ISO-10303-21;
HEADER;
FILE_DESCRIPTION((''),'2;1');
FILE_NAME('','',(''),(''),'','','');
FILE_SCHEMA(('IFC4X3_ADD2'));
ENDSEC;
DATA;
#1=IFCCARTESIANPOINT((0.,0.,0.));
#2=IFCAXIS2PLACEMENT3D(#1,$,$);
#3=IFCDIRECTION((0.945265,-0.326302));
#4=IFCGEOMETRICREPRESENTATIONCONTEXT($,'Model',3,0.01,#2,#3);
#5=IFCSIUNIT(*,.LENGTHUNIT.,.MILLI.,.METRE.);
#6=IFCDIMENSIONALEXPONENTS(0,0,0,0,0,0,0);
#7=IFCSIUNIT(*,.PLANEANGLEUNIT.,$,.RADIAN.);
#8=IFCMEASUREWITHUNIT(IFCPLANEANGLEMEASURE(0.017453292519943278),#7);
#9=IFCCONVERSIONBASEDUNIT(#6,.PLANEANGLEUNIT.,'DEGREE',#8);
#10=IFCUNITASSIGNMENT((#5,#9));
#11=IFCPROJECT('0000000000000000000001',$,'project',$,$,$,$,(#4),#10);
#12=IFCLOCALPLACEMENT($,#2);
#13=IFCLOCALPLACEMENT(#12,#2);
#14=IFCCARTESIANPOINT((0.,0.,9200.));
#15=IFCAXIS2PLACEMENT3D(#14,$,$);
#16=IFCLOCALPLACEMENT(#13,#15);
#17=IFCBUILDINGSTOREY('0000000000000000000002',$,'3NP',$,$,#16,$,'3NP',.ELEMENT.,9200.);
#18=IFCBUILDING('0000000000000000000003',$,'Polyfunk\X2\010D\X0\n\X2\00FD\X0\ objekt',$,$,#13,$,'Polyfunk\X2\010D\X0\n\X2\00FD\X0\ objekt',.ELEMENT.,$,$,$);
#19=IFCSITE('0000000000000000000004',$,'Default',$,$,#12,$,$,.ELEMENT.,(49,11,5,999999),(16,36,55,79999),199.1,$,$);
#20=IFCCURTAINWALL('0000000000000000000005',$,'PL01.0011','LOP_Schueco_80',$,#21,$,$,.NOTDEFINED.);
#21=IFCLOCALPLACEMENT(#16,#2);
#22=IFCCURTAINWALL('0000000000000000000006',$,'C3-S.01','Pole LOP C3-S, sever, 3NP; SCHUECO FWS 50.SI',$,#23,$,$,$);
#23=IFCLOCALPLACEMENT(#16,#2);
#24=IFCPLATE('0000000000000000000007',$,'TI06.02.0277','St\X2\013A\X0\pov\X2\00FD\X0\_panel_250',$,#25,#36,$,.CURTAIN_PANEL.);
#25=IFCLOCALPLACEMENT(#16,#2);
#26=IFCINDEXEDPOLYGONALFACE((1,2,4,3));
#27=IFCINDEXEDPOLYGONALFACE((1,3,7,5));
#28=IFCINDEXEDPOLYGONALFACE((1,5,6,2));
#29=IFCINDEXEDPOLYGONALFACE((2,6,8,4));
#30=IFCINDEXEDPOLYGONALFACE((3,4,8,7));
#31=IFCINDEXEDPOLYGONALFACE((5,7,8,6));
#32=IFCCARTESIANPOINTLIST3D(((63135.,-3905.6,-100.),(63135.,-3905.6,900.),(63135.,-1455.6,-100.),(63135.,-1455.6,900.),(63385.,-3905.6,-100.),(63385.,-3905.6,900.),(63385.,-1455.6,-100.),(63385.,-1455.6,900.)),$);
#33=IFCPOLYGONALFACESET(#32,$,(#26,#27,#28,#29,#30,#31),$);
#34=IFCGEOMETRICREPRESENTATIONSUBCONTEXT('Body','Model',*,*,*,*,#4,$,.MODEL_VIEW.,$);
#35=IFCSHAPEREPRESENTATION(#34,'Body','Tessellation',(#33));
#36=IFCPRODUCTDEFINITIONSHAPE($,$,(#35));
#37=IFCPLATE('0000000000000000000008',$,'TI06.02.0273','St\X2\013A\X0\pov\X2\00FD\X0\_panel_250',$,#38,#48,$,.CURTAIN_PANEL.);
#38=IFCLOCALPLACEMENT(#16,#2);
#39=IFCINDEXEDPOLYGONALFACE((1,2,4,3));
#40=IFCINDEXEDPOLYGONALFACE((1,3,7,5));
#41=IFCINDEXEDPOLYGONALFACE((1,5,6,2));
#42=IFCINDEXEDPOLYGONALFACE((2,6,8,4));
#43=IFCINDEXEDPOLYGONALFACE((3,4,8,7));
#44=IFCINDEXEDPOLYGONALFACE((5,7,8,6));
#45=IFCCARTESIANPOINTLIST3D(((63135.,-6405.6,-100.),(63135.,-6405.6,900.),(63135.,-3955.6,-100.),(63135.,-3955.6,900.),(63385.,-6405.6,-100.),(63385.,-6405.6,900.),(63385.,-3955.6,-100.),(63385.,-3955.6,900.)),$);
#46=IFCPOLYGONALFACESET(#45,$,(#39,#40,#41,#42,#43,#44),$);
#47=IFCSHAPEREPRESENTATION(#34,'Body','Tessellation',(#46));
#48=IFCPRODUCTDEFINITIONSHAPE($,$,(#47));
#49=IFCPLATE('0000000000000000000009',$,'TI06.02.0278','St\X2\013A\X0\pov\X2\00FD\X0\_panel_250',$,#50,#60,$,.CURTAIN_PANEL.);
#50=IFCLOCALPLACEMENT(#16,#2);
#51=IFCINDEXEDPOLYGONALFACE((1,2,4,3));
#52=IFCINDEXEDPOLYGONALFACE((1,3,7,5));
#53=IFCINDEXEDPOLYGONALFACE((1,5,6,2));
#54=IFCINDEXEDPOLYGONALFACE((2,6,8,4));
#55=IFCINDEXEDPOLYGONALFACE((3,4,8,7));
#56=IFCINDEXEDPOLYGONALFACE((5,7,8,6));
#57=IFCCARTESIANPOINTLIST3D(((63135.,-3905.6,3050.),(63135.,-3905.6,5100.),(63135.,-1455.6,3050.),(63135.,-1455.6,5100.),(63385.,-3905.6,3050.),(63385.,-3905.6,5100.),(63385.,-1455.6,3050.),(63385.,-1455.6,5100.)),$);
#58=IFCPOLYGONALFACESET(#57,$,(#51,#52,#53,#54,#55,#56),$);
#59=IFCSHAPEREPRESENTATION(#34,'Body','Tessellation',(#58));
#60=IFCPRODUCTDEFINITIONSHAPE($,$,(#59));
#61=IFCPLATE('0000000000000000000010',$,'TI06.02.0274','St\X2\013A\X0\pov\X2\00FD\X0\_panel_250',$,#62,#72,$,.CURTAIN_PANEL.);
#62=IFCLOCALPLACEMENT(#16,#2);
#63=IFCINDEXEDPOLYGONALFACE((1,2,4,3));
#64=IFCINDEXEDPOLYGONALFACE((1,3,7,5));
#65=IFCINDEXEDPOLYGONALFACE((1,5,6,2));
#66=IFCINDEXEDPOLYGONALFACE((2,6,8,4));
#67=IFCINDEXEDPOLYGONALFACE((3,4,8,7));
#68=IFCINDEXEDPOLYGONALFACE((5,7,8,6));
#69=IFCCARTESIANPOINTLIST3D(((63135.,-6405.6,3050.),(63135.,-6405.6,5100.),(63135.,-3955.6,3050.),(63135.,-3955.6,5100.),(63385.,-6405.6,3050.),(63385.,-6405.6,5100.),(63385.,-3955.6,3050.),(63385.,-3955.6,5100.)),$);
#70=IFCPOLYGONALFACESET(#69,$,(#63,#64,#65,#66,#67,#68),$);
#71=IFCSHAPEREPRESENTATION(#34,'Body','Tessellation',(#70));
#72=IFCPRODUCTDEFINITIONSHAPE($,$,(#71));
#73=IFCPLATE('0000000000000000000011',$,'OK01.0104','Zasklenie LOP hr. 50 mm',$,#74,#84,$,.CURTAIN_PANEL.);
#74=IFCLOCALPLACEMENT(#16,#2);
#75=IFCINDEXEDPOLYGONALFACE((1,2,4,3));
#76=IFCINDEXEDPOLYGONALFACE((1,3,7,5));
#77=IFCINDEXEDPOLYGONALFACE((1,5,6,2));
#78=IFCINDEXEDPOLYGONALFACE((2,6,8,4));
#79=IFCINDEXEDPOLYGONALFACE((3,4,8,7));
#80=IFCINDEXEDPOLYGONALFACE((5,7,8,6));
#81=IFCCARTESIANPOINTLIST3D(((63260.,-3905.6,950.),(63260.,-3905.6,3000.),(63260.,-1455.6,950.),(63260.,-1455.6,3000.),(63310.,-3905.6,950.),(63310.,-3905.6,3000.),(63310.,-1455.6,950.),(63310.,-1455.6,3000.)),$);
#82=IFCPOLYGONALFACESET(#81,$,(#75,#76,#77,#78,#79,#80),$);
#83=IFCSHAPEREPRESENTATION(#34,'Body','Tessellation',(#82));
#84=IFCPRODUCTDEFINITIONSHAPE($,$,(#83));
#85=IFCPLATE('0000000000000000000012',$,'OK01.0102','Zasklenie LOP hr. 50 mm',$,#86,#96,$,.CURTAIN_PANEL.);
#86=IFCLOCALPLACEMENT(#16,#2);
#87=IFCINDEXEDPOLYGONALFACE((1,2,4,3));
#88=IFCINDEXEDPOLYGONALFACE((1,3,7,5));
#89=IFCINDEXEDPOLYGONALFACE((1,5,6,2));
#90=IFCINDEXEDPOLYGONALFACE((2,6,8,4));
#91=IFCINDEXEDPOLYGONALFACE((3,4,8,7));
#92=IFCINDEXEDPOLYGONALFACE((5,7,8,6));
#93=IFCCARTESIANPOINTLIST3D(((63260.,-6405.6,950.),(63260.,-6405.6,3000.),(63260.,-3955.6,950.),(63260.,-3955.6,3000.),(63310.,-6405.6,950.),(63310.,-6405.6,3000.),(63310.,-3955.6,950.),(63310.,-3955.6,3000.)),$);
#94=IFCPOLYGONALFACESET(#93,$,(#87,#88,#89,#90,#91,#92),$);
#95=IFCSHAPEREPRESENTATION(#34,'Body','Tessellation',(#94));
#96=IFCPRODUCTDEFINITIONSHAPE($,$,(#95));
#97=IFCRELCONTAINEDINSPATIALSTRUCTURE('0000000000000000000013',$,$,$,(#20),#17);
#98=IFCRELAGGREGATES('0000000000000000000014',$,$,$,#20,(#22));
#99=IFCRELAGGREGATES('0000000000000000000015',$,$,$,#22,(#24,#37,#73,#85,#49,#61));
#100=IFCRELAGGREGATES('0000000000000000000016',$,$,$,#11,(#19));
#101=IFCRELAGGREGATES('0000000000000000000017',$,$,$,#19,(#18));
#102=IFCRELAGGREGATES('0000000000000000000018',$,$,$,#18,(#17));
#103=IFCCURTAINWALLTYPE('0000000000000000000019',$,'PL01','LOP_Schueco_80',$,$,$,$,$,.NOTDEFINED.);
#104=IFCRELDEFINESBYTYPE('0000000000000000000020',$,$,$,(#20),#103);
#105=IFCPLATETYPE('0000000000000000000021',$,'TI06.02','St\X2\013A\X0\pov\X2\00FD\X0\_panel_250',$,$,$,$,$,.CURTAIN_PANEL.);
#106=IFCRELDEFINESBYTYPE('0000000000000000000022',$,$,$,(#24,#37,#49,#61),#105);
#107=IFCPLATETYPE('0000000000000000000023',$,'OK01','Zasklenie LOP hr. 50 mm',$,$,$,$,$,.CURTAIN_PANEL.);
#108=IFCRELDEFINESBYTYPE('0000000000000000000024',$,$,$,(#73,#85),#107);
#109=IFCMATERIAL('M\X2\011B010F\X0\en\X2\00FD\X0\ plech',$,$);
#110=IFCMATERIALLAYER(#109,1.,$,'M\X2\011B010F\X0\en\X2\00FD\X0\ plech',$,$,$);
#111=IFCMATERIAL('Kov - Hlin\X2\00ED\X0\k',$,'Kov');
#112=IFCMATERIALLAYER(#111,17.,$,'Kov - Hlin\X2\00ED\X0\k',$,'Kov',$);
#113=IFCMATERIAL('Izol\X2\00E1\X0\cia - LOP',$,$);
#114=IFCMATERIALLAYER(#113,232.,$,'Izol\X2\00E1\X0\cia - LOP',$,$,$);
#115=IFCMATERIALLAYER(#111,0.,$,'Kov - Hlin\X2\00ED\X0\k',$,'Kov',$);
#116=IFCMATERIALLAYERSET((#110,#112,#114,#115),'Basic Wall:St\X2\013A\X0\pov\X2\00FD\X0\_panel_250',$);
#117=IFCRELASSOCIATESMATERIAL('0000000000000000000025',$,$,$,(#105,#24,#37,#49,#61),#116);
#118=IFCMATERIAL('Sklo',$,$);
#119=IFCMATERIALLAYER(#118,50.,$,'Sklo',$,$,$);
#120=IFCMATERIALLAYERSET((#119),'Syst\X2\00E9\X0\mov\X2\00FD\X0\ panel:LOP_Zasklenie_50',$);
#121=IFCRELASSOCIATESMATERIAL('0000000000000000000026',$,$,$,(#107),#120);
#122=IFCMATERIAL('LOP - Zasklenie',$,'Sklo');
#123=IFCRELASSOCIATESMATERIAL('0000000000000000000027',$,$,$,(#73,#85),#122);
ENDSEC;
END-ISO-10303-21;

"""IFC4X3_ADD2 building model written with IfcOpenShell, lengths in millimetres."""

from ifc_helpers import new_model, entity, si_unit, converted_unit, direction, frame, frame_2d, origin, origin_2d_with_axis, place, context, subcontext, project, spatial, rectangle, extrude, source, transform, mapped, material, layer, layer_set, layer_usage, type_object, type_shapes, element, aggregate, save


model = new_model("IFC4X3_ADD2")

# Units and contexts
model_context = context("Model", 3, precision=0.01, world=origin(), true_north=direction((0.945265, -0.326302)))
body_context = subcontext(model_context, "Body", "Model", "MODEL_VIEW")
ifc_project = project(units=[si_unit("LENGTHUNIT", "METRE", prefix="MILLI"), converted_unit("PLANEANGLEUNIT", "DEGREE", entity("IfcPlaneAngleMeasure", 0.017453292519943278), si_unit("PLANEANGLEUNIT", "RADIAN"), dimensions=[0, 0, 0, 0, 0, 0, 0])], contexts=[model_context])

# Site, building, storey
site_placement = place(None, origin())
site = spatial("IfcSite", under=ifc_project, at=site_placement, Name="Default", CompositionType="ELEMENT", RefLatitude=(49, 11, 5, 999999), RefLongitude=(16, 36, 55, 79999), RefElevation=199.1)
building_placement = place(site_placement, origin())
building = spatial("IfcBuilding", under=site, at=building_placement, Name="Polyfunkčný objekt", LongName="Polyfunkčný objekt", CompositionType="ELEMENT")
storey_placement = place(building_placement, frame((0.0, 0.0, 9200.0)))
storey = spatial("IfcBuildingStorey", under=building, at=storey_placement, Name="3NP", LongName="3NP", CompositionType="ELEMENT", Elevation=9200.0)

# Curtain walls, plates
curtain_wall_type = type_object("IfcCurtainWallType", Name="PL01", Description="LOP_Schueco_80", PredefinedType="NOTDEFINED")
curtain_wall_1_placement = place(storey_placement, frame((0.0, 0.0, -9200.0)))
curtain_wall_1 = element("IfcCurtainWall", 1, at=curtain_wall_1_placement, inside=storey, type_object=curtain_wall_type, Name="PL01.0011", Description="LOP_Schueco_80", PredefinedType="NOTDEFINED")
curtain_wall_2 = element("IfcCurtainWall", 2, Name="C3-S.01", Description="Pole LOP C3-S, sever, 3NP; SCHUECO FWS 50.SI")
aggregate(curtain_wall_1, [curtain_wall_2])
ifc_material_1 = material(Name="Měďený plech")
ifc_layer_1 = layer(ifc_material_1, 1.0, Name="Měďený plech")
ifc_material_2 = material(Name="Kov - Hliník", Category="Kov")
ifc_layer_2 = layer(ifc_material_2, 17.0, Name="Kov - Hliník", Category="Kov")
ifc_material_3 = material(Name="Izolácia - LOP")
ifc_layer_3 = layer(ifc_material_3, 232.0, Name="Izolácia - LOP")
ifc_layer_4 = layer(ifc_material_2, 0.0, Name="Kov - Hliník", Category="Kov")
ifc_layer_set_1 = layer_set([ifc_layer_1, ifc_layer_2, ifc_layer_3, ifc_layer_4], Name="Basic Wall:Stĺpový_panel_250")
ifc_layer_usage_1 = layer_usage(ifc_layer_set_1, "AXIS2", "NEGATIVE", 125.0)
plate_type_1 = type_object("IfcPlateType", Name="TI06.02", Description="Stĺpový_panel_250", PredefinedType="CURTAIN_PANEL", material=ifc_layer_set_1)
plate_1_placement = place(storey_placement, frame((63260.0, -1455.6, -100.0), z_axis=(0.0, 0.0, 1.0), x_axis=(0.0, -1.0, 0.0)))
plate_1 = element("IfcPlate", 3, at=plate_1_placement, type_object=plate_type_1, material=ifc_layer_usage_1, Name="TI06.02.0277", Description="Stĺpový_panel_250", PredefinedType="CURTAIN_PANEL", context=body_context, shape_type="SweptSolid", body=[
    extrude(rectangle(XDim=250.0, YDim=2450.0, at=frame_2d((0.0, 0.0), x_axis=(1.0, 0.0))), frame((1225.0, 0.0, 0.0), z_axis=(0.0, 0.0, 1.0), x_axis=(0.0, 1.0, 0.0)), (0.0, 0.0, 1.0), 1000.0),
])
ifc_layer_usage_2 = layer_usage(ifc_layer_set_1, "AXIS2", "NEGATIVE", 125.0)
plate_2_placement = place(storey_placement, frame((63260.0, -3955.6, -100.0), z_axis=(0.0, 0.0, 1.0), x_axis=(0.0, -1.0, 0.0)))
plate_2 = element("IfcPlate", 4, at=plate_2_placement, type_object=plate_type_1, material=ifc_layer_usage_2, Name="TI06.02.0273", Description="Stĺpový_panel_250", PredefinedType="CURTAIN_PANEL", context=body_context, shape_type="SweptSolid", body=[
    extrude(rectangle(XDim=250.0, YDim=2450.0, at=frame_2d((0.0, 0.0), x_axis=(1.0, 0.0))), frame((1225.0, 0.0, 0.0), z_axis=(0.0, 0.0, 1.0), x_axis=(0.0, 1.0, 0.0)), (0.0, 0.0, 1.0), 1000.0),
])
ifc_layer_usage_3 = layer_usage(ifc_layer_set_1, "AXIS2", "NEGATIVE", 125.0)
plate_3_placement = place(storey_placement, frame((63260.0, -1455.6, 3050.0), z_axis=(0.0, 0.0, 1.0), x_axis=(0.0, -1.0, 0.0)))
plate_3 = element("IfcPlate", 5, at=plate_3_placement, type_object=plate_type_1, material=ifc_layer_usage_3, Name="TI06.02.0278", Description="Stĺpový_panel_250", PredefinedType="CURTAIN_PANEL", context=body_context, shape_type="SweptSolid", body=[
    extrude(rectangle(XDim=250.0, YDim=2450.0, at=frame_2d((0.0, 0.0), x_axis=(1.0, 0.0))), frame((1225.0, 0.0, 0.0), z_axis=(0.0, 0.0, 1.0), x_axis=(0.0, 1.0, 0.0)), (0.0, 0.0, 1.0), 2050.0),
])
ifc_layer_usage_4 = layer_usage(ifc_layer_set_1, "AXIS2", "NEGATIVE", 125.0)
plate_4_placement = place(storey_placement, frame((63260.0, -3955.6, 3050.0), z_axis=(0.0, 0.0, 1.0), x_axis=(0.0, -1.0, 0.0)))
plate_4 = element("IfcPlate", 6, at=plate_4_placement, type_object=plate_type_1, material=ifc_layer_usage_4, Name="TI06.02.0274", Description="Stĺpový_panel_250", PredefinedType="CURTAIN_PANEL", context=body_context, shape_type="SweptSolid", body=[
    extrude(rectangle(XDim=250.0, YDim=2450.0, at=frame_2d((0.0, 0.0), x_axis=(1.0, 0.0))), frame((1225.0, 0.0, 0.0), z_axis=(0.0, 0.0, 1.0), x_axis=(0.0, 1.0, 0.0)), (0.0, 0.0, 1.0), 2050.0),
])
ifc_material_4 = material(Name="LOP - Zasklenie", Category="Sklo")
ifc_material_5 = material(Name="Sklo")
ifc_layer_5 = layer(ifc_material_5, 50.0, Name="Sklo")
ifc_layer_set_2 = layer_set([ifc_layer_5], Name="Systémový panel:LOP_Zasklenie_50")
plate_type_2 = type_object("IfcPlateType", Name="OK01", Description="Zasklenie LOP hr. 50 mm", PredefinedType="CURTAIN_PANEL", material=ifc_layer_set_2)
shared_shape_1 = source(origin(), body_context, "Body", "SweptSolid", [
    extrude(rectangle(XDim=50.0, YDim=2450.0, at=origin_2d_with_axis()), frame((0.0, 25.0, 0.0), z_axis=(0.0, 0.0, 1.0), x_axis=(0.0, 1.0, 0.0)), (0.0, 0.0, 1.0), 2050.0),
])
type_shapes(plate_type_2, [shared_shape_1])
plate_5_placement = place(curtain_wall_1_placement, frame((63260.0, -2680.6, 10150.0), z_axis=(0.0, 0.0, 1.0), x_axis=(0.0, -1.0, 0.0)))
plate_5 = element("IfcPlate", 7, at=plate_5_placement, type_object=plate_type_2, material=ifc_material_4, Name="OK01.0104", Description="Zasklenie LOP hr. 50 mm", PredefinedType="CURTAIN_PANEL", context=body_context, shape_type="MappedRepresentation", body=[
    mapped(shared_shape_1, transform((0.0, 0.0, 0.0), scale=1.0)),
])
plate_6_placement = place(curtain_wall_1_placement, frame((63260.0, -5180.6, 10150.0), z_axis=(0.0, 0.0, 1.0), x_axis=(0.0, -1.0, 0.0)))
plate_6 = element("IfcPlate", 8, at=plate_6_placement, type_object=plate_type_2, material=ifc_material_4, Name="OK01.0102", Description="Zasklenie LOP hr. 50 mm", PredefinedType="CURTAIN_PANEL", context=body_context, shape_type="MappedRepresentation", body=[
    mapped(shared_shape_1, transform((0.0, 0.0, 0.0), scale=1.0)),
])
aggregate(curtain_wall_2, [plate_1, plate_2, plate_5, plate_6, plate_3, plate_4])

save(model, "model.ifc")
